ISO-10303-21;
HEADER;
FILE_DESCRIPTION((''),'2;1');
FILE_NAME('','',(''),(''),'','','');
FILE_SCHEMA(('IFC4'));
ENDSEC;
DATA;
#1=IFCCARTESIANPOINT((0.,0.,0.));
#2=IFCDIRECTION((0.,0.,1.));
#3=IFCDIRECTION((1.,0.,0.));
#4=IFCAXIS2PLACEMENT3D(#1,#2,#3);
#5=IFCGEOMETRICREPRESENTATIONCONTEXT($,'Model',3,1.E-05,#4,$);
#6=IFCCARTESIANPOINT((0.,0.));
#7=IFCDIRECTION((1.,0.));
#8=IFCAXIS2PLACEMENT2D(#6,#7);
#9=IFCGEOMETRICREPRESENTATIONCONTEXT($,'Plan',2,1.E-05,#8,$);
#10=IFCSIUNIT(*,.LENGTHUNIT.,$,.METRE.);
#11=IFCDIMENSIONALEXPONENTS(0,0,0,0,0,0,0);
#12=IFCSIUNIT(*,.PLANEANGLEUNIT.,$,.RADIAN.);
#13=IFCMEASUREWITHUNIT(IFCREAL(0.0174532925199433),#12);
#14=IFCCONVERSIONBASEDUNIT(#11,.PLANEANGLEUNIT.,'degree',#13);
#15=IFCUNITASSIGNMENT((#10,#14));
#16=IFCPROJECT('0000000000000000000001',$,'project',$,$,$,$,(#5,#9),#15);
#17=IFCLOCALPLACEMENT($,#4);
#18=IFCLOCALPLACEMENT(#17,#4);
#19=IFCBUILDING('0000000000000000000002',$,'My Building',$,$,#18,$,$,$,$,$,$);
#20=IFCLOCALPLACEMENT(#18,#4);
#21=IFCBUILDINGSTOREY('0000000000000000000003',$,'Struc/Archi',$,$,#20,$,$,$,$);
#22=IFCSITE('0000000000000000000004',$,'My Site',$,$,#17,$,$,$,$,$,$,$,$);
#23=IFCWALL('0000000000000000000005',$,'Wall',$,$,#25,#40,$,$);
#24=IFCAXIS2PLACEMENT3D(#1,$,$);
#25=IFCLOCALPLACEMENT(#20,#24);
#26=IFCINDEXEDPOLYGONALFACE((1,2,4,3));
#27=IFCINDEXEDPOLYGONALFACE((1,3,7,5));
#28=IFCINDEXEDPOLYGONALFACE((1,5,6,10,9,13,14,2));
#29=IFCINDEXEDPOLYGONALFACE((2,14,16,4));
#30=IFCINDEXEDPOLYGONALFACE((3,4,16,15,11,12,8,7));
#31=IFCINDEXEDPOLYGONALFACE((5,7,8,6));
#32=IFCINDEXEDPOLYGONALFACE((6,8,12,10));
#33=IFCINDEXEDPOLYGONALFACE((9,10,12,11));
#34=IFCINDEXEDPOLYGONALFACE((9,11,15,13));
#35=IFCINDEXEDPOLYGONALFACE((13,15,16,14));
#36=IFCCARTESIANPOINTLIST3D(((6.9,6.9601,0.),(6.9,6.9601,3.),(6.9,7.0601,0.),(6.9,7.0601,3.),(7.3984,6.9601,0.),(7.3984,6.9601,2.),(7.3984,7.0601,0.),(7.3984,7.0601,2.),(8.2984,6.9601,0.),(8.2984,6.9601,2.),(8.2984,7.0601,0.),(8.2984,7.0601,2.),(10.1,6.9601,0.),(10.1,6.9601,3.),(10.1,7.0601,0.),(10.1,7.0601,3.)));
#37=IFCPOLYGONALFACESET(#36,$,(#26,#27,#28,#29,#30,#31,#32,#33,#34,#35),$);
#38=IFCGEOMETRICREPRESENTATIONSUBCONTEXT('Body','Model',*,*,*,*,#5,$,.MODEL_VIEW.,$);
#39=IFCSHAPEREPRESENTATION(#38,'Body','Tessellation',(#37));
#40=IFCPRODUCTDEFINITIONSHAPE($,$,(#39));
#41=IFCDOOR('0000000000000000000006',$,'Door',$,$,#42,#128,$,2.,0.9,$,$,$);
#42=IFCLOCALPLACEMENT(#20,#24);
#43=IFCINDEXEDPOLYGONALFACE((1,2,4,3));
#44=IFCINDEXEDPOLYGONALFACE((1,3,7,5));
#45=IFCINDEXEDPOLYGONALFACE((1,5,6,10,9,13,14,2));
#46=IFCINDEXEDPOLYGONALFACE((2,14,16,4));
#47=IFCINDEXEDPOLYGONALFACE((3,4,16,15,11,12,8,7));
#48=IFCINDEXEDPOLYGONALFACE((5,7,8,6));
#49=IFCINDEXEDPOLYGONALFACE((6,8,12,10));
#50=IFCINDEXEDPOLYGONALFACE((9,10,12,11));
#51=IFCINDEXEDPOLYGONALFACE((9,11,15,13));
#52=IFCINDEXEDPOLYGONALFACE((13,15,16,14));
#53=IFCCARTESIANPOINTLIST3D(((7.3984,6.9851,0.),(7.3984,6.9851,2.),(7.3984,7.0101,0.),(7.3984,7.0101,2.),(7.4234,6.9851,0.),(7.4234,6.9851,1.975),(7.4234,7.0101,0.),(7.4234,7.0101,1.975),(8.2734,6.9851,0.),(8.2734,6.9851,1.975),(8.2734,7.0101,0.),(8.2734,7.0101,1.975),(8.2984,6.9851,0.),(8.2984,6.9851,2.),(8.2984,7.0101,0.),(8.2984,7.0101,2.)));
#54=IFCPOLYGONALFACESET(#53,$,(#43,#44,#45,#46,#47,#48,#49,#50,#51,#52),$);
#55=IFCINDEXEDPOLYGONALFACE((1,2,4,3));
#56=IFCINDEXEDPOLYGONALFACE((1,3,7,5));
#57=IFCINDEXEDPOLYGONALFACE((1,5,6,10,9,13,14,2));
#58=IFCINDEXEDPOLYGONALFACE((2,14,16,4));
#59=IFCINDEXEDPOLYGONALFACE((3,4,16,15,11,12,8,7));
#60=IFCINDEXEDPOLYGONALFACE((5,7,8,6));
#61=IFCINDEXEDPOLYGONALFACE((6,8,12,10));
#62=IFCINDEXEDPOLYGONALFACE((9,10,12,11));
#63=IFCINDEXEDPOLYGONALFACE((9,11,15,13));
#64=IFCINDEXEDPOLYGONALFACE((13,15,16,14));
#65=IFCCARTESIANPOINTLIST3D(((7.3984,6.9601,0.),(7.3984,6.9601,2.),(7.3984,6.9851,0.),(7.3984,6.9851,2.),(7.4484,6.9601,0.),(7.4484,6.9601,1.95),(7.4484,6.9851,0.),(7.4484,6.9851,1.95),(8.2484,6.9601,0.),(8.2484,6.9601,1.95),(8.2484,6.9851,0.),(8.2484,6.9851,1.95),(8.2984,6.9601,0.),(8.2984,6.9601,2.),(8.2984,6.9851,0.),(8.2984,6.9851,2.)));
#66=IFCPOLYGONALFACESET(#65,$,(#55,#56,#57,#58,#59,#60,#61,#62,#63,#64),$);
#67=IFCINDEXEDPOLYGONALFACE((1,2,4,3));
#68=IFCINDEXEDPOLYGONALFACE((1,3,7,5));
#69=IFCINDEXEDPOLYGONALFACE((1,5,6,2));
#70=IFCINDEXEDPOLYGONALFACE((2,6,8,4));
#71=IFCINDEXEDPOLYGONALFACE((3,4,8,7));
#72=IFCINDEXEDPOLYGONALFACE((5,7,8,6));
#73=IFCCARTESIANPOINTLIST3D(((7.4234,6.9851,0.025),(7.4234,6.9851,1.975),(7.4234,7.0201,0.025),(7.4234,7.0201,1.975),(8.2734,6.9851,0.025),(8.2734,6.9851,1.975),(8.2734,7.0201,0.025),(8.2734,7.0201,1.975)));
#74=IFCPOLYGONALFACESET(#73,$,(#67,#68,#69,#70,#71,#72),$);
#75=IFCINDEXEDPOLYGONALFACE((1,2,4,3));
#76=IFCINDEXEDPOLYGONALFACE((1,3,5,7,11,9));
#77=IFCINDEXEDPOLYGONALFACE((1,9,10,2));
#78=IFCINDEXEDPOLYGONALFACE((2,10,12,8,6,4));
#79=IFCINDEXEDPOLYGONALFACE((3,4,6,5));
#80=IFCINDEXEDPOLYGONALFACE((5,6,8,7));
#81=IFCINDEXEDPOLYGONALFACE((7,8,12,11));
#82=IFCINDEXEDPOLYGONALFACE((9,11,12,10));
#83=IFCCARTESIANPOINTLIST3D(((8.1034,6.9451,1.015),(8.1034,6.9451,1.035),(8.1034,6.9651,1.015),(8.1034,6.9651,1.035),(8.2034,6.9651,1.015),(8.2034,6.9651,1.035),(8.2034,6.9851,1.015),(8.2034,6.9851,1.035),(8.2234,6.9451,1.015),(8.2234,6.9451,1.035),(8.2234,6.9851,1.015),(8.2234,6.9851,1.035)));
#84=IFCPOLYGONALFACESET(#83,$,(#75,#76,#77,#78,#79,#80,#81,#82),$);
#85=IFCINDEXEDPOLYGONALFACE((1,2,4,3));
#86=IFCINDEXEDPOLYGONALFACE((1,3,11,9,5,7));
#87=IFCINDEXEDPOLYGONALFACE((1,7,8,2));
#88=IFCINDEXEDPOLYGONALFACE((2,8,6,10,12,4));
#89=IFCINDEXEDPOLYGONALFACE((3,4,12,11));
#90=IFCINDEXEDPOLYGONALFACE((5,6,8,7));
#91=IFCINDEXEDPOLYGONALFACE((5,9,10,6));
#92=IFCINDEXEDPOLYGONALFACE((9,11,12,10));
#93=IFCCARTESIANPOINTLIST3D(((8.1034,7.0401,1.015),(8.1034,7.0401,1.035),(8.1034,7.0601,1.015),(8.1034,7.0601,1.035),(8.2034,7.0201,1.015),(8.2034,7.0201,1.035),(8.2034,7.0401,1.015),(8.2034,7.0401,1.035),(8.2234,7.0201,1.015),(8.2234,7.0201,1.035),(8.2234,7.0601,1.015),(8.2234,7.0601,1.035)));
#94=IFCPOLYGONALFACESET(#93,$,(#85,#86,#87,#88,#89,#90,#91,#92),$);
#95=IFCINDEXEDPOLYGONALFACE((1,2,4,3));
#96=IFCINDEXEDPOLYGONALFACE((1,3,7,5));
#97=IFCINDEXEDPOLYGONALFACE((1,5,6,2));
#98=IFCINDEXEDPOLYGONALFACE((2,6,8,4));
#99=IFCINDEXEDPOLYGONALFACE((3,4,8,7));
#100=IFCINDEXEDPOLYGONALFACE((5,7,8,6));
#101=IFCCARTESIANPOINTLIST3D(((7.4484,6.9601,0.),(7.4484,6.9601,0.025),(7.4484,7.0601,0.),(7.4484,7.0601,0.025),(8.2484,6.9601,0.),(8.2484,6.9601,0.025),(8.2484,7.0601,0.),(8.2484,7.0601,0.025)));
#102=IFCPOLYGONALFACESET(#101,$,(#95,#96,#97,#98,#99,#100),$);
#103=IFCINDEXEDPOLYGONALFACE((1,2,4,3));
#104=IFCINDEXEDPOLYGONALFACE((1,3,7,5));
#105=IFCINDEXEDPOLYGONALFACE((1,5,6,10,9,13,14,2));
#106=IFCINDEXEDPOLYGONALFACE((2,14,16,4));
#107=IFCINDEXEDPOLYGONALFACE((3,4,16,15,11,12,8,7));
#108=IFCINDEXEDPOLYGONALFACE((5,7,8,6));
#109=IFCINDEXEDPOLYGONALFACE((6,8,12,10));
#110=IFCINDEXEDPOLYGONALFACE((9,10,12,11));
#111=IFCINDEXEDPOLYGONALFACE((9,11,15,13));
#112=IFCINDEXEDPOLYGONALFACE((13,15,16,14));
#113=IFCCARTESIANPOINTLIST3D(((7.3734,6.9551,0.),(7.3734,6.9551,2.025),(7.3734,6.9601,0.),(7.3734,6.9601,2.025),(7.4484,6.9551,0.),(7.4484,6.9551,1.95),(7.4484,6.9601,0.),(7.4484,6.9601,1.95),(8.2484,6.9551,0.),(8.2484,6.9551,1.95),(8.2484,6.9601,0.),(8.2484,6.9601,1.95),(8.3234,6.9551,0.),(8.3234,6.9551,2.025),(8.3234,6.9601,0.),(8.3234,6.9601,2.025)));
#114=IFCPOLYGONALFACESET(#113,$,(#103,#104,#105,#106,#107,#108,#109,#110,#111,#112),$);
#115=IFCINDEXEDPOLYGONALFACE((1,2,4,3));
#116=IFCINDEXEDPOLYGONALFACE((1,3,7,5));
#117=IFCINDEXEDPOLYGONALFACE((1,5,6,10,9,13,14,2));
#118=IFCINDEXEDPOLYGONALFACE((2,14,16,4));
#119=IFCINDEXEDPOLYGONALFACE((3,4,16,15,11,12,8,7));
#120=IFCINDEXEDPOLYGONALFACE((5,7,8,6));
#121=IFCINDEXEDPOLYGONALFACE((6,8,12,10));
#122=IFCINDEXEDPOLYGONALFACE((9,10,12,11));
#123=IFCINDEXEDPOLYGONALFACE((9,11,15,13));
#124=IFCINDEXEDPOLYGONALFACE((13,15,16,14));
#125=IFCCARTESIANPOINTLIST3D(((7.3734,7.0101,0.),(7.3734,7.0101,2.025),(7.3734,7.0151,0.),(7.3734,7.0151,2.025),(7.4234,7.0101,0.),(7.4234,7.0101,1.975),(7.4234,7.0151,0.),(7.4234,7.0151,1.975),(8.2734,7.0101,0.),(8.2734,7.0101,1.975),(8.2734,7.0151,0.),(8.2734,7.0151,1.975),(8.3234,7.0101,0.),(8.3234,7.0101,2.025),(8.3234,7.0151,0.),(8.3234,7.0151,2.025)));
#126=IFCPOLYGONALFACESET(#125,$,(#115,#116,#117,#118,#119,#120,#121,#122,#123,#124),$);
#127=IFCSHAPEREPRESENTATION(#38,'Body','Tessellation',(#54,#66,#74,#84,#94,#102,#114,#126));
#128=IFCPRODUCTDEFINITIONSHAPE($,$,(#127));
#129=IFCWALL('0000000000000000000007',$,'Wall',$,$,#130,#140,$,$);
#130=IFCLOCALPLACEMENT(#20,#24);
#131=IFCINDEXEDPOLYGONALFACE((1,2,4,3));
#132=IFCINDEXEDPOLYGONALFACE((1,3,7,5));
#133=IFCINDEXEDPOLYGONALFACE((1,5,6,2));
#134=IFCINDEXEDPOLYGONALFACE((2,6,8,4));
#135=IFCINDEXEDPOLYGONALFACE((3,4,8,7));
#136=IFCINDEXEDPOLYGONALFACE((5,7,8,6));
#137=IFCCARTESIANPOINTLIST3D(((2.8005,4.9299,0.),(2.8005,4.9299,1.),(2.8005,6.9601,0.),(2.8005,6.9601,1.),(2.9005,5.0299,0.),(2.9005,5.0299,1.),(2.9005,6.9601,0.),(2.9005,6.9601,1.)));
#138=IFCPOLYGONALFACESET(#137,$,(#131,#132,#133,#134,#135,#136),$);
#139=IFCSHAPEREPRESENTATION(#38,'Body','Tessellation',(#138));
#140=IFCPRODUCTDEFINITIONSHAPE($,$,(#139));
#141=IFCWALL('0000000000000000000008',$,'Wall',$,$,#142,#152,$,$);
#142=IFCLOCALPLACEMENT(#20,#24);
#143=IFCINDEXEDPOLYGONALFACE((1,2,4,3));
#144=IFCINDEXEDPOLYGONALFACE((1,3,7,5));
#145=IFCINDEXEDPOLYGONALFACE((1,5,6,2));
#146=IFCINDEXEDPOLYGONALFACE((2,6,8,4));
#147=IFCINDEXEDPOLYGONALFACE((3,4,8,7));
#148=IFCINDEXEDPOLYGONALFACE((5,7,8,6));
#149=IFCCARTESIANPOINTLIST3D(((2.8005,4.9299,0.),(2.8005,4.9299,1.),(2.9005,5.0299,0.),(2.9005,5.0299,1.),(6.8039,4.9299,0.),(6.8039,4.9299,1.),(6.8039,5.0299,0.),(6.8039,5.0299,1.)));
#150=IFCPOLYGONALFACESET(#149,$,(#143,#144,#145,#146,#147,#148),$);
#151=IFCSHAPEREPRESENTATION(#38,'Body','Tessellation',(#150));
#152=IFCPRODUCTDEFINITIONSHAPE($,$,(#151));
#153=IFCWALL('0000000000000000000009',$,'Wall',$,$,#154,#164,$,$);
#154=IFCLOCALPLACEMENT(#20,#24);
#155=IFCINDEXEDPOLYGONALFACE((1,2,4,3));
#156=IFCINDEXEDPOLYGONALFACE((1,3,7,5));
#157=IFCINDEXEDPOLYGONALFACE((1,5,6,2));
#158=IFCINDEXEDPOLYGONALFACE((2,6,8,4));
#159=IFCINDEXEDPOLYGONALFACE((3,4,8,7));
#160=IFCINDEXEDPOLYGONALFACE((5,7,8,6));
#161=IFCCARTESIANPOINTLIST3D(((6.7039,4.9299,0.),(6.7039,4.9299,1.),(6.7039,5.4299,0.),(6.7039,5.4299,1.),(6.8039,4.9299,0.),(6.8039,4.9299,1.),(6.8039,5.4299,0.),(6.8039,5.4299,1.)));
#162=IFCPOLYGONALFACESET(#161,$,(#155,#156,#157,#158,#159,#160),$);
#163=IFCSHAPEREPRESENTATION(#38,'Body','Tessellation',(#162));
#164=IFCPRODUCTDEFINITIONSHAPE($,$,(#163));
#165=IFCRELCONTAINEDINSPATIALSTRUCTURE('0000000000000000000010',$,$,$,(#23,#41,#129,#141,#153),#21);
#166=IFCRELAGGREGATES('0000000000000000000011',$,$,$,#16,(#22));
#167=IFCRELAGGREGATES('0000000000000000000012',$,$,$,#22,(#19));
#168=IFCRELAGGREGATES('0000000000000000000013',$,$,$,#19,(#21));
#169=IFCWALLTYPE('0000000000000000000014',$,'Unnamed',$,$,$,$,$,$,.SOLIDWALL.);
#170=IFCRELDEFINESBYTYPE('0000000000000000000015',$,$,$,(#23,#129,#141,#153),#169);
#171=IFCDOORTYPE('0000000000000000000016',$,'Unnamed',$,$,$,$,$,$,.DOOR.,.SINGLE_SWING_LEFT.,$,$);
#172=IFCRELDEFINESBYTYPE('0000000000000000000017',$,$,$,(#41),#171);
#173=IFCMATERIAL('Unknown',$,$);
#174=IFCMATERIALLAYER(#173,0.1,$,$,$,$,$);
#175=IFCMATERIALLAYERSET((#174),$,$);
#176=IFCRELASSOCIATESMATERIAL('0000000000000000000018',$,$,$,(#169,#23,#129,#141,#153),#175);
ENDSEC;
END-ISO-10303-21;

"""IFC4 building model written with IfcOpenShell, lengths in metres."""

from ifc_helpers import new_model, entity, si_unit, converted_unit, frame, origin_with_axes, origin_2d_with_axis, place, context, subcontext, project, spatial, line, indexed_curve, outline, extrude, shape, source, transform, mapped, material, layer, layer_set, layer_usage, type_object, type_shapes, element, fill, save


model = new_model("IFC4")

# Units and contexts
model_context = context("Model", 3, precision=1e-05, world=origin_with_axes())
plan_context = context("Plan", 2, precision=1e-05, world=origin_2d_with_axis())
body_context_1 = subcontext(model_context, "Body", "Model", "MODEL_VIEW")
body_context_2 = subcontext(plan_context, "Body", "Plan", "PLAN_VIEW")
ifc_project = project(units=[si_unit("LENGTHUNIT", "METRE"), converted_unit("PLANEANGLEUNIT", "degree", entity("IfcReal", 0.0174532925199433), si_unit("PLANEANGLEUNIT", "RADIAN"), dimensions=[0, 0, 0, 0, 0, 0, 0])], contexts=[model_context, plan_context])

# Site, building, storey
site_placement = place(None, origin_with_axes())
site = spatial("IfcSite", under=ifc_project, at=site_placement, Name="My Site")
building_placement = place(site_placement, origin_with_axes())
building = spatial("IfcBuilding", under=site, at=building_placement, Name="My Building")
storey_placement = place(building_placement, origin_with_axes())
storey = spatial("IfcBuildingStorey", under=building, at=storey_placement, Name="Struc/Archi")

# Shared definitions
ifc_material = material(Name="Unknown")

# Shared definitions
ifc_layer_1 = layer(ifc_material, 0.1)
ifc_layer_set_1 = layer_set([ifc_layer_1])
wall_type = type_object("IfcWallType", Name="Unnamed", PredefinedType="SOLIDWALL", material=ifc_layer_set_1)

# Shared definitions
shared_shape_1 = source(origin_with_axes(), body_context_1, "Body", "SweptSolid", [
    extrude(outline(indexed_curve([(0.0, 0.0), (0.9, 0.0), (0.9, 2.0), (0.0, 2.0)], segments=[line(1, 2, 3, 4, 1)])), frame((0.0, -0.6, 0.0), z_axis=(0.0, -1.0, 0.0), x_axis=(1.0, 0.0, 0.0)), (0.0, 0.0, -1.0), 1.2),
])
door_type = type_object("IfcDoorType", Name="Unnamed", OperationType="SINGLE_SWING_LEFT", PredefinedType="DOOR")
shared_shape_2 = source(origin_with_axes(), body_context_1, "Body", "SweptSolid", [
    extrude(outline(indexed_curve([(0.0, 0.0), (0.0, 2.0), (0.9, 2.0), (0.9, 0.0), (0.875, 0.0), (0.875, 1.975), (0.025, 1.975), (0.025, 0.0)], segments=[line(1, 2, 3, 4, 5, 6, 7, 8, 1)])), frame((0.0, 0.025, 0.0), z_axis=(0.0, -1.0, 0.0), x_axis=(1.0, 0.0, 0.0)), (0.0, 0.0, -1.0), 0.025),
    extrude(outline(indexed_curve([(0.0, 0.0), (0.0, 2.0), (0.9, 2.0), (0.9, 0.0), (0.85, 0.0), (0.85, 1.95), (0.05, 1.95), (0.05, 0.0)], segments=[line(1, 2, 3, 4, 5, 6, 7, 8, 1)])), frame((0.0, 0.0, 0.0), z_axis=(0.0, -1.0, 0.0), x_axis=(1.0, 0.0, 0.0)), (0.0, 0.0, -1.0), 0.025),
    extrude(outline(indexed_curve([(0.0, 0.0), (0.85, 0.0), (0.85, 0.035), (0.0, 0.035)], segments=[line(1, 2, 3, 4, 1)])), frame((0.025, 0.025, 0.025), z_axis=(0.0, 0.0, 1.0), x_axis=(1.0, 0.0, 0.0)), (0.0, 0.0, 1.0), 1.95),
    extrude(outline(indexed_curve([(0.0, 0.0), (0.0, -0.04), (-0.12, -0.04), (-0.12, -0.02), (-0.02, -0.02), (-0.02, 0.0)], segments=[line(1, 2, 3, 4, 5, 6, 1)])), frame((0.825, 0.025, 1.015), z_axis=(0.0, 0.0, 1.0), x_axis=(1.0, 0.0, 0.0)), (0.0, 0.0, 1.0), 0.02),
    extrude(outline(indexed_curve([(0.0, 0.0), (0.0, 0.04), (-0.12, 0.04), (-0.12, 0.02), (-0.02, 0.02), (-0.02, 0.0)], segments=[line(1, 2, 3, 4, 5, 6, 1)])), frame((0.825, 0.06, 1.015), z_axis=(0.0, 0.0, 1.0), x_axis=(1.0, 0.0, 0.0)), (0.0, 0.0, 1.0), 0.02),
    extrude(outline(indexed_curve([(0.0, 0.0), (0.8, 0.0), (0.8, 0.1), (0.0, 0.1)], segments=[line(1, 2, 3, 4, 1)])), frame((0.05, 0.0, 0.0), z_axis=(0.0, 0.0, 1.0), x_axis=(1.0, 0.0, 0.0)), (0.0, 0.0, 1.0), 0.025),
    extrude(outline(indexed_curve([(0.0, 0.0), (0.0, 2.025), (0.95, 2.025), (0.95, 0.0), (0.875, 0.0), (0.875, 1.95), (0.075, 1.95), (0.075, 0.0)], segments=[line(1, 2, 3, 4, 5, 6, 7, 8, 1)])), frame((-0.025, -0.005, 0.0), z_axis=(0.0, -1.0, 0.0), x_axis=(1.0, 0.0, 0.0)), (0.0, 0.0, -1.0), 0.005),
    extrude(outline(indexed_curve([(0.0, 0.0), (0.0, 2.025), (0.95, 2.025), (0.95, 0.0), (0.9, 0.0), (0.9, 1.975), (0.05, 1.975), (0.05, 0.0)], segments=[line(1, 2, 3, 4, 5, 6, 7, 8, 1)])), frame((-0.025, 0.05, 0.0), z_axis=(0.0, -1.0, 0.0), x_axis=(1.0, 0.0, 0.0)), (0.0, 0.0, -1.0), 0.005),
])
shared_shape_3 = source(origin_with_axes(), body_context_2, "Body", "Curve2D", [
    entity("IfcIndexedPolyCurve", entity("IfcCartesianPointList2D", [[0.0, 0.0], [0.0, 0.05], [0.025, 0.05], [0.025, 0.025], [0.05, 0.025], [0.05, 0.0]]), [entity("IfcLineIndex", [1, 2, 3, 4, 5, 6, 1])]),
    entity("IfcIndexedPolyCurve", entity("IfcCartesianPointList2D", [[0.9, 0.0], [0.9, 0.05], [0.875, 0.05], [0.875, 0.025], [0.85, 0.025], [0.85, 0.0]]), [entity("IfcLineIndex", [1, 2, 3, 4, 5, 6, 1])]),
    entity("IfcTrimmedCurve", entity("IfcEllipse", entity("IfcAxis2Placement2D", entity("IfcCartesianPoint", [0.06, 0.05]), entity("IfcDirection", [1.0, 0.0])), 0.815, 0.85), [entity("IfcCartesianPoint", [0.875, 0.05])], [entity("IfcCartesianPoint", [0.06, 0.9])], True, "CARTESIAN"),
    entity("IfcIndexedPolyCurve", entity("IfcCartesianPointList2D", [[0.025, 0.05], [0.06, 0.05], [0.06, 0.9], [0.025, 0.9]]), [entity("IfcLineIndex", [1, 2, 3, 4, 1])]),
])
type_shapes(door_type, [shared_shape_2, shared_shape_3])

# Wall, opening, door
ifc_layer_usage_1 = layer_usage(ifc_layer_set_1, "AXIS2", "POSITIVE", 0.0)
wall_1_placement = place(storey_placement, frame((6.9, 6.9601, 0.0), z_axis=(0.0, 0.0, 1.0), x_axis=(1.0, 0.0, 0.0)))
wall_1 = element("IfcWall", 1, at=wall_1_placement, inside=storey, type_object=wall_type, material=ifc_layer_usage_1, Name="Wall", context=body_context_1, shape_type="SweptSolid", body=[
    extrude(outline(indexed_curve([(0.0, 0.0), (0.0, 0.1), (3.2, 0.1), (3.2, 0.0)], segments=[line(1, 2, 3, 4, 1)])), origin_with_axes(), (0.0, 0.0, 1.0), 3.0),
])
opening_1_placement = place(wall_1_placement, frame((0.4984, 0.0, 0.0), z_axis=(0.0, 0.0, 1.0), x_axis=(1.0, 0.0, 0.0)))
opening_1 = element("IfcOpeningElement", 2, at=opening_1_placement, cuts=wall_1, PredefinedType="OPENING", context=body_context_1, shape_type="MappedRepresentation", body=[
    mapped(shared_shape_1, transform((0.0, 0.0, 0.0), x_axis=(1.0, 0.0, 0.0), y_axis=(0.0, 1.0, 0.0), z_axis=(0.0, 0.0, 1.0), scale=1.0)),
])
door_1_placement = place(opening_1_placement, frame((0.0, 0.0, 0.0), z_axis=(0.0, 0.0, 1.0), x_axis=(1.0, 0.0, 0.0)))
door_1 = element("IfcDoor", 3, at=door_1_placement, inside=storey, type_object=door_type, Name="Door", OverallHeight=2.0, OverallWidth=0.9, shapes=[
    shape(body_context_1, "Body", "MappedRepresentation", [mapped(shared_shape_2, transform((0.0, 0.0, 0.0), x_axis=(1.0, 0.0, 0.0), y_axis=(0.0, 1.0, 0.0), z_axis=(0.0, 0.0, 1.0), scale=1.0))]),
    shape(body_context_2, "Body", "MappedRepresentation", [mapped(shared_shape_3, transform((0.0, 0.0, 0.0), x_axis=(1.0, 0.0, 0.0), y_axis=(0.0, 1.0, 0.0), z_axis=(0.0, 0.0, 1.0), scale=1.0))]),
])
fill(opening_1, door_1)

# Walls
ifc_layer_usage_2 = layer_usage(ifc_layer_set_1, "AXIS2", "POSITIVE", 0.0)
wall_2_placement = place(storey_placement, frame((2.8005, 6.9601, 0.0), z_axis=(0.0, 0.0, 1.0), x_axis=(0.0, -1.0, 0.0)))
element("IfcWall", 4, at=wall_2_placement, inside=storey, type_object=wall_type, material=ifc_layer_usage_2, Name="Wall", context=body_context_1, shape_type="SweptSolid", body=[
    extrude(outline(indexed_curve([(0.0, 0.0), (0.0, 0.1), (1.9301, 0.1), (2.0301, 0.0)], segments=[line(1, 2, 3, 4, 1)])), origin_with_axes(), (0.0, 0.0, 1.0), 1.0),
])
ifc_layer_usage_3 = layer_usage(ifc_layer_set_1, "AXIS2", "POSITIVE", 0.0)
wall_3_placement = place(storey_placement, frame((2.8005, 4.9299, 0.0), z_axis=(0.0, 0.0, 1.0), x_axis=(1.0, 0.0, 0.0)))
element("IfcWall", 5, at=wall_3_placement, inside=storey, type_object=wall_type, material=ifc_layer_usage_3, Name="Wall", context=body_context_1, shape_type="SweptSolid", body=[
    extrude(outline(indexed_curve([(0.0, 0.0), (0.1, 0.1), (4.0034, 0.1), (4.0034, 0.0)], segments=[line(1, 2, 3, 4, 1)])), origin_with_axes(), (0.0, 0.0, 1.0), 1.0),
])
ifc_layer_usage_4 = layer_usage(ifc_layer_set_1, "AXIS2", "POSITIVE", 0.0)
wall_4_placement = place(storey_placement, frame((6.7039, 5.4299, 0.0), z_axis=(0.0, 0.0, 1.0), x_axis=(0.0, -1.0, 0.0)))
element("IfcWall", 6, at=wall_4_placement, inside=storey, type_object=wall_type, material=ifc_layer_usage_4, Name="Wall", context=body_context_1, shape_type="SweptSolid", body=[
    extrude(outline(indexed_curve([(0.0, 0.0), (0.0, 0.1), (0.5, 0.1), (0.5, 0.0)], segments=[line(1, 2, 3, 4, 1)])), origin_with_axes(), (0.0, 0.0, 1.0), 1.0),
])

save(model, "model.ifc")
